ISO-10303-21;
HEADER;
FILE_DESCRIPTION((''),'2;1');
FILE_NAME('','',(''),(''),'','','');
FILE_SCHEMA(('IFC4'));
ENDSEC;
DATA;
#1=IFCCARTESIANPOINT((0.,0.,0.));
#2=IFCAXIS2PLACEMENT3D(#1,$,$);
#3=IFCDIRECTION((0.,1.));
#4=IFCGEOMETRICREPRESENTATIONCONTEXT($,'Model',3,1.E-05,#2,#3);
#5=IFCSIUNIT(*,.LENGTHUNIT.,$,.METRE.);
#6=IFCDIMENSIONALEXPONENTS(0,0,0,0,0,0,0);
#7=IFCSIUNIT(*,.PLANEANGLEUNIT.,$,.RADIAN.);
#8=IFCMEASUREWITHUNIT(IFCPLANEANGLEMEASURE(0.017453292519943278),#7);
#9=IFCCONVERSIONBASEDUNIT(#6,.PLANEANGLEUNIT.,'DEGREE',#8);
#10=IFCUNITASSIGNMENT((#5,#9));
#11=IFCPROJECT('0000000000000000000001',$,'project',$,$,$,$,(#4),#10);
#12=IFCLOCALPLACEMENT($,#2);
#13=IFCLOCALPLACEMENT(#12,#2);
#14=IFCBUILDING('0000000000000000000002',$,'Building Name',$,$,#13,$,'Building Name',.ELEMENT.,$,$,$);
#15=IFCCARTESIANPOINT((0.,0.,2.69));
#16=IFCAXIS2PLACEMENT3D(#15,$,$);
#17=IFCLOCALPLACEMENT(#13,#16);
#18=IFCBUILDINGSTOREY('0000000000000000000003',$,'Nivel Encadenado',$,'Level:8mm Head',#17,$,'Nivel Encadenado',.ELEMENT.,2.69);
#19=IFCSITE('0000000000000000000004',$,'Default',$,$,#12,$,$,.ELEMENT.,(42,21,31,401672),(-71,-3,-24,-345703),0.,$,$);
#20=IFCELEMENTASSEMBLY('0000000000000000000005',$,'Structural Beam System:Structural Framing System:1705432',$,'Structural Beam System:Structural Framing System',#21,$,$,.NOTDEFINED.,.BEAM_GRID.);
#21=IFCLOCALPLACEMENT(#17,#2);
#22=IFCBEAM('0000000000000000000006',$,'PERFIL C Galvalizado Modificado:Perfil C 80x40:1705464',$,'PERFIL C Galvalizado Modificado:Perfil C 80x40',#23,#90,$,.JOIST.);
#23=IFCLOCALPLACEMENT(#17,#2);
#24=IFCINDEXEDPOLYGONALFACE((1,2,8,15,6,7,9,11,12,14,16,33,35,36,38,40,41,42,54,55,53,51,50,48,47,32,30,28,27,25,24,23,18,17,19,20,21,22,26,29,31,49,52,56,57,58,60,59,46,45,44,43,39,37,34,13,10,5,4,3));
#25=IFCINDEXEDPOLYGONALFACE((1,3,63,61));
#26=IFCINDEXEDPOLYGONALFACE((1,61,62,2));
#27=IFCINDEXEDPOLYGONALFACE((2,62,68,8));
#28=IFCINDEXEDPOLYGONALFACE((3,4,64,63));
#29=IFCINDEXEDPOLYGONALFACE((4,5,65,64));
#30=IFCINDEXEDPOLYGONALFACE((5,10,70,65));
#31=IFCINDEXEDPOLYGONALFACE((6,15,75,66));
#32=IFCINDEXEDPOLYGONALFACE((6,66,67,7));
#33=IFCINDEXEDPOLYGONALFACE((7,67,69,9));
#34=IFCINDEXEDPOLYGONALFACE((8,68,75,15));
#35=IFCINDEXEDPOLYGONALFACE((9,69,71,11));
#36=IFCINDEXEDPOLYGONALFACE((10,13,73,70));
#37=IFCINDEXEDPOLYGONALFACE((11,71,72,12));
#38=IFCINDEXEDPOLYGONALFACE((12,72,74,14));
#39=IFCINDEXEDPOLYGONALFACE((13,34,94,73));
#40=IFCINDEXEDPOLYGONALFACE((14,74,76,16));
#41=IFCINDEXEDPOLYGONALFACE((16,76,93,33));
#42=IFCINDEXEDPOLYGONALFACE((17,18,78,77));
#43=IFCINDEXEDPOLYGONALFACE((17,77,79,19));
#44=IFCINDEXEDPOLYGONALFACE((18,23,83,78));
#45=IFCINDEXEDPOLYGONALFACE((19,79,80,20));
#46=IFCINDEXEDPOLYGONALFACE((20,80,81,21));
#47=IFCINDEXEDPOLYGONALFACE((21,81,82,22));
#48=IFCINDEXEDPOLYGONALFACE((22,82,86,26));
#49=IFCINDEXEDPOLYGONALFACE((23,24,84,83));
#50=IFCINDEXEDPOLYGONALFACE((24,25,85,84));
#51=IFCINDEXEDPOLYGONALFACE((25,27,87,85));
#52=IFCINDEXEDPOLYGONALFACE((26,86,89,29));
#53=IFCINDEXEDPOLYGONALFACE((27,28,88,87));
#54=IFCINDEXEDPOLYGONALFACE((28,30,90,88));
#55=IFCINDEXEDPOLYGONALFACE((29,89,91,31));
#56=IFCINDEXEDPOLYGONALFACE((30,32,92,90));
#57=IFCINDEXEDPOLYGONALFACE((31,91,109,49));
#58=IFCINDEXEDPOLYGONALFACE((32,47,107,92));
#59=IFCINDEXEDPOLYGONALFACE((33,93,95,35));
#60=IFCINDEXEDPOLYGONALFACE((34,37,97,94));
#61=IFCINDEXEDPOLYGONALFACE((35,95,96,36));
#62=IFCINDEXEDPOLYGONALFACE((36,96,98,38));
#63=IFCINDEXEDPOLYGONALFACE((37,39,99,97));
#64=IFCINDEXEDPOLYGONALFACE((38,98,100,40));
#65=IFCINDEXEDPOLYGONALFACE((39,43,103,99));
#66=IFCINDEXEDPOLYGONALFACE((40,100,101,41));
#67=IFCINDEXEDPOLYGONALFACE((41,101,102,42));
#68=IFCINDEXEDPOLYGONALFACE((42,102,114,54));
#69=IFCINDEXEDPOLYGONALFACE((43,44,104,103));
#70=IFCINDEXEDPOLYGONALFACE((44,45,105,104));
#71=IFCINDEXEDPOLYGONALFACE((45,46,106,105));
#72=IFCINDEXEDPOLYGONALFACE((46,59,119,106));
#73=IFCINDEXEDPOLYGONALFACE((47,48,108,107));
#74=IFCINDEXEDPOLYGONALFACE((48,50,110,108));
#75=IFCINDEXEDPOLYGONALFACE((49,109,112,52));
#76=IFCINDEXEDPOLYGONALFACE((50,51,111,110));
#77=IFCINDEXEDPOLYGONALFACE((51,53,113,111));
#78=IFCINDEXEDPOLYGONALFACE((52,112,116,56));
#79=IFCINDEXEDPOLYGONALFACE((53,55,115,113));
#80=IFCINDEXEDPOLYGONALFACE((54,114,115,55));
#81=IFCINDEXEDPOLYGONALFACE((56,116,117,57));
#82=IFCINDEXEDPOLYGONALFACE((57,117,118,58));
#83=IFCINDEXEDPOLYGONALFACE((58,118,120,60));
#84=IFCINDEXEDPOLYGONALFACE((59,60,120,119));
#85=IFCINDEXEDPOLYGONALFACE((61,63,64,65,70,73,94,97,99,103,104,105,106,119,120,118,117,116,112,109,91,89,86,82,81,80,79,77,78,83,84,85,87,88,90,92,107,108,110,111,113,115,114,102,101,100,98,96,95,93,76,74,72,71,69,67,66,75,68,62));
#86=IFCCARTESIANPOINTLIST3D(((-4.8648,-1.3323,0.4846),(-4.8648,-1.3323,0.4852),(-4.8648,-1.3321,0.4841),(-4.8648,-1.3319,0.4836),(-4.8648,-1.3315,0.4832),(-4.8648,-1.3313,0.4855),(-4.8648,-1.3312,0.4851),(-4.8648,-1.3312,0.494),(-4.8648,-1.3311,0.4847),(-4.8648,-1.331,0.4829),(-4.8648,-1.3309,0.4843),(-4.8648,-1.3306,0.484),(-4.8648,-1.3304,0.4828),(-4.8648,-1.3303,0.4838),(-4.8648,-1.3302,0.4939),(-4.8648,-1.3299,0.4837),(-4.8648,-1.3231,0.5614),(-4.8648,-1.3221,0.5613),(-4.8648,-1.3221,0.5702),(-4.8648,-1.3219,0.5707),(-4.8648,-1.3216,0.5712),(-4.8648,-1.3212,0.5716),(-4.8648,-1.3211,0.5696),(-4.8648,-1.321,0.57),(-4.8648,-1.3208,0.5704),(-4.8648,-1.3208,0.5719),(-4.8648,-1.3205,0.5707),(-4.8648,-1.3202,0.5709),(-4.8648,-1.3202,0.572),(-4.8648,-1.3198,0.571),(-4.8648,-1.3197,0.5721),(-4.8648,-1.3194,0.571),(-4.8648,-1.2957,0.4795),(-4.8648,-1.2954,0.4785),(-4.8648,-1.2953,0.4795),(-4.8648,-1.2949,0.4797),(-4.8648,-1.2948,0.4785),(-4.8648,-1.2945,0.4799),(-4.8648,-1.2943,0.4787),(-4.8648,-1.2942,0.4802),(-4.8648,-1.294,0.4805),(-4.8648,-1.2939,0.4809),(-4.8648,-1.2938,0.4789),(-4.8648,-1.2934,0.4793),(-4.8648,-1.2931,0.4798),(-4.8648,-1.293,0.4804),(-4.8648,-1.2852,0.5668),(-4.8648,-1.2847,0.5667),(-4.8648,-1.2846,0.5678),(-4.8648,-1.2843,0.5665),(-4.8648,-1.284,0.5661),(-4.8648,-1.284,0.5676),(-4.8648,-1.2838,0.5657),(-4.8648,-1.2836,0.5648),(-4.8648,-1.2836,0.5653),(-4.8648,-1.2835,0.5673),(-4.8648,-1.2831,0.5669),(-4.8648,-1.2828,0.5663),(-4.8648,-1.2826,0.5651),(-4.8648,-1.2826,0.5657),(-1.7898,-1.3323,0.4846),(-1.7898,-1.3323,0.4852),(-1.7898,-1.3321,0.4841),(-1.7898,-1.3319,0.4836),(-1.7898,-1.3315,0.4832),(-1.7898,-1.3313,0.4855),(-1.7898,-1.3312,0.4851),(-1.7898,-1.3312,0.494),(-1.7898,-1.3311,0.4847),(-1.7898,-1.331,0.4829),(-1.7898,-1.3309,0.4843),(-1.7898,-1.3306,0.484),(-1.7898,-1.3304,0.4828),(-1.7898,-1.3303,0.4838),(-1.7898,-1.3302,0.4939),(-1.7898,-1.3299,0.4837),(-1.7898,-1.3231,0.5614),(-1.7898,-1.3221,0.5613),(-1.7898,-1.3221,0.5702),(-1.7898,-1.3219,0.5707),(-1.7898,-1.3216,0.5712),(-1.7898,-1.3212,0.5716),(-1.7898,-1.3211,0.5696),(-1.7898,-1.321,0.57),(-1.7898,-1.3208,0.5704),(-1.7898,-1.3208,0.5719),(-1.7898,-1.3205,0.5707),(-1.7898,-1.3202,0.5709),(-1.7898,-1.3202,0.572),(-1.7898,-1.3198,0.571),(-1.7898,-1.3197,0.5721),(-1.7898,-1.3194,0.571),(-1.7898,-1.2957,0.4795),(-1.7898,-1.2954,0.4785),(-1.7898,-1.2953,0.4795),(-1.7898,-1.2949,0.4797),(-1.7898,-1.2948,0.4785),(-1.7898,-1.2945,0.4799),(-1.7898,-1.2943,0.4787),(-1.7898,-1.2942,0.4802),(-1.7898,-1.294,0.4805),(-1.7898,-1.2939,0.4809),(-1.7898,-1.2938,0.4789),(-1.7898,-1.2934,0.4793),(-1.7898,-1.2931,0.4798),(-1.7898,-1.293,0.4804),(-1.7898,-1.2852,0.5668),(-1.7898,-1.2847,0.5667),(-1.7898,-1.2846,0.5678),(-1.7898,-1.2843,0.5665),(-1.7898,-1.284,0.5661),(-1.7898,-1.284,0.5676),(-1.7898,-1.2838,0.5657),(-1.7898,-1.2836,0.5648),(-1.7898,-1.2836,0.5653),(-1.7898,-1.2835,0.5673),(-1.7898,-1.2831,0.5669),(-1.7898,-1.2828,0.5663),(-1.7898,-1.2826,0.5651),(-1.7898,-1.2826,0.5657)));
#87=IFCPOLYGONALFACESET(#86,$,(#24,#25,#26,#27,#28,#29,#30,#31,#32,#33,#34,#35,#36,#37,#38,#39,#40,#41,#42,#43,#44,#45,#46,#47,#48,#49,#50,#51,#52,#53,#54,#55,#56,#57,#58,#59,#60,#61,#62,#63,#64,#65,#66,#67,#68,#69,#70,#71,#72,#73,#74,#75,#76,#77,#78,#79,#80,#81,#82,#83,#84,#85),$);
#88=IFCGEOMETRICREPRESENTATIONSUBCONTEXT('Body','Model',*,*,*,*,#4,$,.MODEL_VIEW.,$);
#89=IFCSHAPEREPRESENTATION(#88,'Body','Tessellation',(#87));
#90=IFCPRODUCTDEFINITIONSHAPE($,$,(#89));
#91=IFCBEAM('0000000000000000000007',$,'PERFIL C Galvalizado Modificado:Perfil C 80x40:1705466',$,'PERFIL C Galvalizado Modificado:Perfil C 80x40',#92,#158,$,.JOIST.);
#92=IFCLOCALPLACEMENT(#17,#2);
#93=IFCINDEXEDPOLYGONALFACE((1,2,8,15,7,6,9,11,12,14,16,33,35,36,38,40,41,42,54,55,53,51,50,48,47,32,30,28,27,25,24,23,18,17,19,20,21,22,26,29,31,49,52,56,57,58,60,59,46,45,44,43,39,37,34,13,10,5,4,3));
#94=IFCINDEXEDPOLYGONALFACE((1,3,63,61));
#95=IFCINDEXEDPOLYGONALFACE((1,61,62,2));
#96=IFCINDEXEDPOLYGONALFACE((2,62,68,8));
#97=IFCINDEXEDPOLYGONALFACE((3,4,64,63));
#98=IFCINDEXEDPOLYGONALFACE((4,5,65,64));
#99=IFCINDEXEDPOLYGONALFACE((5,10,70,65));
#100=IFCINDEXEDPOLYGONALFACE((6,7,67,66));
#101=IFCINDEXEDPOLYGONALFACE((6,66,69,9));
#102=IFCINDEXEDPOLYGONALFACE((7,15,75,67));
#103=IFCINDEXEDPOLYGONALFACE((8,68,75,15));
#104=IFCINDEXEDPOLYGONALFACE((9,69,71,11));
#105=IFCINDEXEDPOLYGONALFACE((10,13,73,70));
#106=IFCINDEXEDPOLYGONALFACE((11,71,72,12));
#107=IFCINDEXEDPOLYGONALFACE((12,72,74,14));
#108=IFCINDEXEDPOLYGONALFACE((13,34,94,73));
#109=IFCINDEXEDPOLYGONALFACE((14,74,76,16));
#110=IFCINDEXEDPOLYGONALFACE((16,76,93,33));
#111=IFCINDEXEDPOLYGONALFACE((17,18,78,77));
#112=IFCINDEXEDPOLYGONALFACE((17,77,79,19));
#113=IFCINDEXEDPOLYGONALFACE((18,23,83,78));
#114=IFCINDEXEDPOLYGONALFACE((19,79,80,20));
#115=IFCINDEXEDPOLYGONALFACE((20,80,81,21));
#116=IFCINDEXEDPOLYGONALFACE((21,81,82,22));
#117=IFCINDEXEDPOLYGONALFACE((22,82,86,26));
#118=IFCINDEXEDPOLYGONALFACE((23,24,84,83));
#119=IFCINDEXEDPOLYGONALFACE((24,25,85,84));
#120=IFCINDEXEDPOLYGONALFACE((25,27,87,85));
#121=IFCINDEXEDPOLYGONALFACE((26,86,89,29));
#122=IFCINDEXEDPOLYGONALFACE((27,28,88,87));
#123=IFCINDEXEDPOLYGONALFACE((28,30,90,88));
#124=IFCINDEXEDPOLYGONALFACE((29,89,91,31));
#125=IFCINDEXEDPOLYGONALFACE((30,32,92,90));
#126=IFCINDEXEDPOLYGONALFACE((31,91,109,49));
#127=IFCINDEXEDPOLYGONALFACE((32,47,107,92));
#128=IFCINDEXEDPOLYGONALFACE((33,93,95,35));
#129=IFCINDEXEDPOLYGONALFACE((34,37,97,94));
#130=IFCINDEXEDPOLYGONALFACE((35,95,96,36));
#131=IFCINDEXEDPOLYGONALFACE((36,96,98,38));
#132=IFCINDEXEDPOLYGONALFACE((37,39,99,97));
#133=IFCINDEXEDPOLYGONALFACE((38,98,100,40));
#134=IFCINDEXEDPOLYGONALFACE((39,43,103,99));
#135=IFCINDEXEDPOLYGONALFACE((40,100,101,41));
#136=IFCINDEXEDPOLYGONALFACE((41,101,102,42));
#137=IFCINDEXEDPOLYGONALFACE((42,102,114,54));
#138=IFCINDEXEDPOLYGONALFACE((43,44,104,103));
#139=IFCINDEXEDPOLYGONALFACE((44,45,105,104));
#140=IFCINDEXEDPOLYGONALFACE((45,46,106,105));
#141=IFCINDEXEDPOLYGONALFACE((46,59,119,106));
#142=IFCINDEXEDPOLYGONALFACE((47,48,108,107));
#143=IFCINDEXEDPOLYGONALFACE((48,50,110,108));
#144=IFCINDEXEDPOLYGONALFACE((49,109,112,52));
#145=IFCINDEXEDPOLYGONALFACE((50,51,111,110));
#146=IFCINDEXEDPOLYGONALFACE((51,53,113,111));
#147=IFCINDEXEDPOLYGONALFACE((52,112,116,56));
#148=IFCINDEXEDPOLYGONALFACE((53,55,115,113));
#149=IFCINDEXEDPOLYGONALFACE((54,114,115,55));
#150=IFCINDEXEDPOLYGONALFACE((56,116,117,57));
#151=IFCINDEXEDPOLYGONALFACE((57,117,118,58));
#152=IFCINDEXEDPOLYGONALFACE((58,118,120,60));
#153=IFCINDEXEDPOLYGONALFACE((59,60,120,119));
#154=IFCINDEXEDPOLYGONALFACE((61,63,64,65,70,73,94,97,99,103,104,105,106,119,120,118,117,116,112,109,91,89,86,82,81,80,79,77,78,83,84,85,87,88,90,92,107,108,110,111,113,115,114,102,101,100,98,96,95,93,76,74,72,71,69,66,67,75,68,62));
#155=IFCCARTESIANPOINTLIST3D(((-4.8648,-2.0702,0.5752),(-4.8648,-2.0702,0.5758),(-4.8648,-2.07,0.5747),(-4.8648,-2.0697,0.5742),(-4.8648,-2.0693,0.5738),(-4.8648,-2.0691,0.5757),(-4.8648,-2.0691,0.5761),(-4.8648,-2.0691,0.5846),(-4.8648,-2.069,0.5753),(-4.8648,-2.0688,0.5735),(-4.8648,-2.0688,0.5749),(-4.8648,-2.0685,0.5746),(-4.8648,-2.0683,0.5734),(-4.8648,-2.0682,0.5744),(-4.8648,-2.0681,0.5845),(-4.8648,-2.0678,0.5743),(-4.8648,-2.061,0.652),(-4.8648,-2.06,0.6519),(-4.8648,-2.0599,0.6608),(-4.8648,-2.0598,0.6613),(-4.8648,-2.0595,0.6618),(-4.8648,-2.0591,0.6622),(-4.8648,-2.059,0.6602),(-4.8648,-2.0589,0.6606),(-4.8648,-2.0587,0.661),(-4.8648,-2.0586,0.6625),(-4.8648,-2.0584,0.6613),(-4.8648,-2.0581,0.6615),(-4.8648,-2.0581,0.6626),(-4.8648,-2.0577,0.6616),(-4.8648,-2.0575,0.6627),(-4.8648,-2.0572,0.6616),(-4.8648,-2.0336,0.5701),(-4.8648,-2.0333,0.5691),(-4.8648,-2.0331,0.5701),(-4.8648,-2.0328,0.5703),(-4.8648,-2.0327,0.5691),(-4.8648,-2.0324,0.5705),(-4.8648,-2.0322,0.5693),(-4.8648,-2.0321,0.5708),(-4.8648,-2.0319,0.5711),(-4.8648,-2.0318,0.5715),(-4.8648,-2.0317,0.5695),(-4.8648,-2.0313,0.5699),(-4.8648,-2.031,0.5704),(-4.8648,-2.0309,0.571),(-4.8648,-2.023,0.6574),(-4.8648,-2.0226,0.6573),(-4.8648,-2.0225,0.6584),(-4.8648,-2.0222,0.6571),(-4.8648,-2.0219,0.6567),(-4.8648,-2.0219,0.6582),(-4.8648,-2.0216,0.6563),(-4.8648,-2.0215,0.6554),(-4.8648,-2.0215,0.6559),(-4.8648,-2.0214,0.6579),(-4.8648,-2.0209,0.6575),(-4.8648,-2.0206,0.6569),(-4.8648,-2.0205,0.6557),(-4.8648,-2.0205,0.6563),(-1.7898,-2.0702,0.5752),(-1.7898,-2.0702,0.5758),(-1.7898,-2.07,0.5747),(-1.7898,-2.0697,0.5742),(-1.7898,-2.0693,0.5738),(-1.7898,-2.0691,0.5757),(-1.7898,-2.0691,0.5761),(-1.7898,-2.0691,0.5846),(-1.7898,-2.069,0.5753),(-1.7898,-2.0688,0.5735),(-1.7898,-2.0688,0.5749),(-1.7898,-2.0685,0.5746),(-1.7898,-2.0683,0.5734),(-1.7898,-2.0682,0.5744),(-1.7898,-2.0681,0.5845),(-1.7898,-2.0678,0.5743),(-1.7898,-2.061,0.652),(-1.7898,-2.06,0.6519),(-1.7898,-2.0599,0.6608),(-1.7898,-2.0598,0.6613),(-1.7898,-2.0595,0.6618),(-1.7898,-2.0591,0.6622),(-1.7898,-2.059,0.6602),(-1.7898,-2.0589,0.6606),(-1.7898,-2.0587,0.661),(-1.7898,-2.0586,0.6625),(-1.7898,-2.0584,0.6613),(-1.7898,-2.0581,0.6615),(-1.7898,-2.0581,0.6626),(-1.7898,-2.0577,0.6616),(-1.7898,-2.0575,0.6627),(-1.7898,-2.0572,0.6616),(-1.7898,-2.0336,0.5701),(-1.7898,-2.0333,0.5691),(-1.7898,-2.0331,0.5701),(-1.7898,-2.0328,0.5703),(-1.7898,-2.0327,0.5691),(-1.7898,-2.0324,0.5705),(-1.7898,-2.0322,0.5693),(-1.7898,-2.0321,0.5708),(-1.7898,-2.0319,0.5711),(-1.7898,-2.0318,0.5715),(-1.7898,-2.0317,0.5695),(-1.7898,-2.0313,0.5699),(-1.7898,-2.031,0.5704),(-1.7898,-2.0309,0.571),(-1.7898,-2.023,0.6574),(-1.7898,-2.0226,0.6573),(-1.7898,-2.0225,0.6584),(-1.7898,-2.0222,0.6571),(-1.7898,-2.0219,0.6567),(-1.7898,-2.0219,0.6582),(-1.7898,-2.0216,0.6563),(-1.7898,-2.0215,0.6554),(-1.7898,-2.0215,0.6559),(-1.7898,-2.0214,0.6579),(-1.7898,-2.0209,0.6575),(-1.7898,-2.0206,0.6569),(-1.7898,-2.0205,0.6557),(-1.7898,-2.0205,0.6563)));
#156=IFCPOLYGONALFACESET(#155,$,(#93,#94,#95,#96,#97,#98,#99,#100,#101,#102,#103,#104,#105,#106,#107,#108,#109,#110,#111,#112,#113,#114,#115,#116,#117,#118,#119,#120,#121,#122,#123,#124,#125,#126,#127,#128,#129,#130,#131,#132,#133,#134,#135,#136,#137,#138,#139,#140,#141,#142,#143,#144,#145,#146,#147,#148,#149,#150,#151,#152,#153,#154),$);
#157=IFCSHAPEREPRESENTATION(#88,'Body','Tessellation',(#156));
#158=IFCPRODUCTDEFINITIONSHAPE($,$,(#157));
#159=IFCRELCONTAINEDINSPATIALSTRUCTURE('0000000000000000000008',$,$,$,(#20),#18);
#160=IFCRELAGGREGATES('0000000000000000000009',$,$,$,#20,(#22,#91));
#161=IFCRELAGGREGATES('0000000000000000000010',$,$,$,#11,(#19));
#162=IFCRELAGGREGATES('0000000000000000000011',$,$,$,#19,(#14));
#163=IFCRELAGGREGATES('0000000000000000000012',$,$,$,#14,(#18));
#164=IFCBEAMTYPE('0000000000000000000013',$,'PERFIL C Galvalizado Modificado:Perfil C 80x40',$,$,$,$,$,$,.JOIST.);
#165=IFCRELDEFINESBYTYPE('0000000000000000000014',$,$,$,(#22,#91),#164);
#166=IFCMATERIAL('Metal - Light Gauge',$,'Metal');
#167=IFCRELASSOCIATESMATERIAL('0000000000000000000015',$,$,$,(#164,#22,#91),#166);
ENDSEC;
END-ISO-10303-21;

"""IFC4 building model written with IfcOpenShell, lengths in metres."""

from ifc_helpers import new_model, entity, si_unit, converted_unit, direction, frame, origin, place, context, subcontext, project, spatial, line, arc, indexed_curve, outline, extrude, source, transform, mapped, material, type_object, type_shapes, element, aggregate, save


model = new_model("IFC4")

# Units and contexts
model_context = context("Model", 3, precision=1e-05, world=origin(), true_north=direction((0.0, 1.0)))
body_context = subcontext(model_context, "Body", "Model", "MODEL_VIEW")
ifc_project = project(units=[si_unit("LENGTHUNIT", "METRE"), converted_unit("PLANEANGLEUNIT", "DEGREE", entity("IfcPlaneAngleMeasure", 0.017453292519943278), si_unit("PLANEANGLEUNIT", "RADIAN"), dimensions=[0, 0, 0, 0, 0, 0, 0])], contexts=[model_context])

# Site, building, storey
site_placement = place(None, origin())
site = spatial("IfcSite", under=ifc_project, at=site_placement, Name="Default", CompositionType="ELEMENT", RefLatitude=(42, 21, 31, 401672), RefLongitude=(-71, -3, -24, -345703), RefElevation=0.0)
building_placement = place(site_placement, origin())
building = spatial("IfcBuilding", under=site, at=building_placement, Name="Building Name", LongName="Building Name", CompositionType="ELEMENT")
storey_placement = place(building_placement, frame((0.0, 0.0, 2.69)))
storey = spatial("IfcBuildingStorey", under=building, at=storey_placement, Name="Nivel Encadenado", ObjectType="Level:8mm Head", LongName="Nivel Encadenado", CompositionType="ELEMENT", Elevation=2.69)

# Element assembly, beams
ifc_material_1 = material(Name="Metal - Light Gauge", Category="Metal")
assembly_1_placement = place(storey_placement, origin())
assembly_1 = element("IfcElementAssembly", 1, at=assembly_1_placement, inside=storey, Name="Structural Beam System:Structural Framing System:1705432", ObjectType="Structural Beam System:Structural Framing System", AssemblyPlace="NOTDEFINED", PredefinedType="BEAM_GRID")
beam_type_1 = type_object("IfcBeamType", Name="PERFIL C Galvalizado Modificado:Perfil C 80x40", PredefinedType="JOIST", material=ifc_material_1)
shared_shape_1 = source(origin(), body_context, "Body", "SweptSolid", [
    extrude(outline(indexed_curve([(-0.0428, -0.0237), (0.0426, -0.0237), (0.0443, -0.023), (0.045, -0.0214), (0.045, 0.0139), (0.0443, 0.0154), (0.0428, 0.0161), (0.034, 0.0161), (0.034, 0.0151), (0.0424, 0.0151), (0.0435, 0.0146), (0.044, 0.0135), (0.044, -0.021), (0.0435, -0.0222), (0.0422, -0.0227), (-0.0424, -0.0227), (-0.0435, -0.0223), (-0.0439, -0.0212), (-0.0439, 0.0133), (-0.0435, 0.0144), (-0.0424, 0.0149), (-0.0339, 0.0149), (-0.0339, 0.0159), (-0.0428, 0.0159), (-0.0443, 0.0152), (-0.0449, 0.0137), (-0.0449, -0.0216), (-0.0443, -0.0231)], segments=[line(1, 2), arc(2, 3, 4), line(4, 5), arc(5, 6, 7), line(7, 8, 9, 10), arc(10, 11, 12), line(12, 13), arc(13, 14, 15), line(15, 16), arc(16, 17, 18), line(18, 19), arc(19, 20, 21), line(21, 22, 23, 24), arc(24, 25, 26), line(26, 27), arc(27, 28, 1)], self_intersect=False)), frame((-1.5375, -0.0037, 0.0), z_axis=(1.0, 0.0, 0.0), x_axis=(0.0, 0.0, 1.0)), (0.0, 0.0, 1.0), 3.075),
])
type_shapes(beam_type_1, [shared_shape_1])
beam_1_placement = place(assembly_1_placement, frame((-3.3273, -1.3076, 0.5253), z_axis=(0.0, 0.121869, 0.992546), x_axis=(1.0, 0.0, 0.0)))
beam_1 = element("IfcBeam", 2, at=beam_1_placement, type_object=beam_type_1, material=ifc_material_1, Name="PERFIL C Galvalizado Modificado:Perfil C 80x40:1705464", ObjectType="PERFIL C Galvalizado Modificado:Perfil C 80x40", PredefinedType="JOIST", context=body_context, shape_type="MappedRepresentation", body=[
    mapped(shared_shape_1, transform((0.0, 0.0, 0.0), scale=1.0)),
])
beam_2_placement = place(assembly_1_placement, frame((-3.3273, -2.0455, 0.6159), z_axis=(0.0, 0.121869, 0.992546), x_axis=(1.0, 0.0, 0.0)))
beam_2 = element("IfcBeam", 3, at=beam_2_placement, type_object=beam_type_1, material=ifc_material_1, Name="PERFIL C Galvalizado Modificado:Perfil C 80x40:1705466", ObjectType="PERFIL C Galvalizado Modificado:Perfil C 80x40", PredefinedType="JOIST", context=body_context, shape_type="MappedRepresentation", body=[
    mapped(shared_shape_1, transform((0.0, 0.0, 0.0), scale=1.0)),
])
aggregate(assembly_1, [beam_1, beam_2])

save(model, "model.ifc")
